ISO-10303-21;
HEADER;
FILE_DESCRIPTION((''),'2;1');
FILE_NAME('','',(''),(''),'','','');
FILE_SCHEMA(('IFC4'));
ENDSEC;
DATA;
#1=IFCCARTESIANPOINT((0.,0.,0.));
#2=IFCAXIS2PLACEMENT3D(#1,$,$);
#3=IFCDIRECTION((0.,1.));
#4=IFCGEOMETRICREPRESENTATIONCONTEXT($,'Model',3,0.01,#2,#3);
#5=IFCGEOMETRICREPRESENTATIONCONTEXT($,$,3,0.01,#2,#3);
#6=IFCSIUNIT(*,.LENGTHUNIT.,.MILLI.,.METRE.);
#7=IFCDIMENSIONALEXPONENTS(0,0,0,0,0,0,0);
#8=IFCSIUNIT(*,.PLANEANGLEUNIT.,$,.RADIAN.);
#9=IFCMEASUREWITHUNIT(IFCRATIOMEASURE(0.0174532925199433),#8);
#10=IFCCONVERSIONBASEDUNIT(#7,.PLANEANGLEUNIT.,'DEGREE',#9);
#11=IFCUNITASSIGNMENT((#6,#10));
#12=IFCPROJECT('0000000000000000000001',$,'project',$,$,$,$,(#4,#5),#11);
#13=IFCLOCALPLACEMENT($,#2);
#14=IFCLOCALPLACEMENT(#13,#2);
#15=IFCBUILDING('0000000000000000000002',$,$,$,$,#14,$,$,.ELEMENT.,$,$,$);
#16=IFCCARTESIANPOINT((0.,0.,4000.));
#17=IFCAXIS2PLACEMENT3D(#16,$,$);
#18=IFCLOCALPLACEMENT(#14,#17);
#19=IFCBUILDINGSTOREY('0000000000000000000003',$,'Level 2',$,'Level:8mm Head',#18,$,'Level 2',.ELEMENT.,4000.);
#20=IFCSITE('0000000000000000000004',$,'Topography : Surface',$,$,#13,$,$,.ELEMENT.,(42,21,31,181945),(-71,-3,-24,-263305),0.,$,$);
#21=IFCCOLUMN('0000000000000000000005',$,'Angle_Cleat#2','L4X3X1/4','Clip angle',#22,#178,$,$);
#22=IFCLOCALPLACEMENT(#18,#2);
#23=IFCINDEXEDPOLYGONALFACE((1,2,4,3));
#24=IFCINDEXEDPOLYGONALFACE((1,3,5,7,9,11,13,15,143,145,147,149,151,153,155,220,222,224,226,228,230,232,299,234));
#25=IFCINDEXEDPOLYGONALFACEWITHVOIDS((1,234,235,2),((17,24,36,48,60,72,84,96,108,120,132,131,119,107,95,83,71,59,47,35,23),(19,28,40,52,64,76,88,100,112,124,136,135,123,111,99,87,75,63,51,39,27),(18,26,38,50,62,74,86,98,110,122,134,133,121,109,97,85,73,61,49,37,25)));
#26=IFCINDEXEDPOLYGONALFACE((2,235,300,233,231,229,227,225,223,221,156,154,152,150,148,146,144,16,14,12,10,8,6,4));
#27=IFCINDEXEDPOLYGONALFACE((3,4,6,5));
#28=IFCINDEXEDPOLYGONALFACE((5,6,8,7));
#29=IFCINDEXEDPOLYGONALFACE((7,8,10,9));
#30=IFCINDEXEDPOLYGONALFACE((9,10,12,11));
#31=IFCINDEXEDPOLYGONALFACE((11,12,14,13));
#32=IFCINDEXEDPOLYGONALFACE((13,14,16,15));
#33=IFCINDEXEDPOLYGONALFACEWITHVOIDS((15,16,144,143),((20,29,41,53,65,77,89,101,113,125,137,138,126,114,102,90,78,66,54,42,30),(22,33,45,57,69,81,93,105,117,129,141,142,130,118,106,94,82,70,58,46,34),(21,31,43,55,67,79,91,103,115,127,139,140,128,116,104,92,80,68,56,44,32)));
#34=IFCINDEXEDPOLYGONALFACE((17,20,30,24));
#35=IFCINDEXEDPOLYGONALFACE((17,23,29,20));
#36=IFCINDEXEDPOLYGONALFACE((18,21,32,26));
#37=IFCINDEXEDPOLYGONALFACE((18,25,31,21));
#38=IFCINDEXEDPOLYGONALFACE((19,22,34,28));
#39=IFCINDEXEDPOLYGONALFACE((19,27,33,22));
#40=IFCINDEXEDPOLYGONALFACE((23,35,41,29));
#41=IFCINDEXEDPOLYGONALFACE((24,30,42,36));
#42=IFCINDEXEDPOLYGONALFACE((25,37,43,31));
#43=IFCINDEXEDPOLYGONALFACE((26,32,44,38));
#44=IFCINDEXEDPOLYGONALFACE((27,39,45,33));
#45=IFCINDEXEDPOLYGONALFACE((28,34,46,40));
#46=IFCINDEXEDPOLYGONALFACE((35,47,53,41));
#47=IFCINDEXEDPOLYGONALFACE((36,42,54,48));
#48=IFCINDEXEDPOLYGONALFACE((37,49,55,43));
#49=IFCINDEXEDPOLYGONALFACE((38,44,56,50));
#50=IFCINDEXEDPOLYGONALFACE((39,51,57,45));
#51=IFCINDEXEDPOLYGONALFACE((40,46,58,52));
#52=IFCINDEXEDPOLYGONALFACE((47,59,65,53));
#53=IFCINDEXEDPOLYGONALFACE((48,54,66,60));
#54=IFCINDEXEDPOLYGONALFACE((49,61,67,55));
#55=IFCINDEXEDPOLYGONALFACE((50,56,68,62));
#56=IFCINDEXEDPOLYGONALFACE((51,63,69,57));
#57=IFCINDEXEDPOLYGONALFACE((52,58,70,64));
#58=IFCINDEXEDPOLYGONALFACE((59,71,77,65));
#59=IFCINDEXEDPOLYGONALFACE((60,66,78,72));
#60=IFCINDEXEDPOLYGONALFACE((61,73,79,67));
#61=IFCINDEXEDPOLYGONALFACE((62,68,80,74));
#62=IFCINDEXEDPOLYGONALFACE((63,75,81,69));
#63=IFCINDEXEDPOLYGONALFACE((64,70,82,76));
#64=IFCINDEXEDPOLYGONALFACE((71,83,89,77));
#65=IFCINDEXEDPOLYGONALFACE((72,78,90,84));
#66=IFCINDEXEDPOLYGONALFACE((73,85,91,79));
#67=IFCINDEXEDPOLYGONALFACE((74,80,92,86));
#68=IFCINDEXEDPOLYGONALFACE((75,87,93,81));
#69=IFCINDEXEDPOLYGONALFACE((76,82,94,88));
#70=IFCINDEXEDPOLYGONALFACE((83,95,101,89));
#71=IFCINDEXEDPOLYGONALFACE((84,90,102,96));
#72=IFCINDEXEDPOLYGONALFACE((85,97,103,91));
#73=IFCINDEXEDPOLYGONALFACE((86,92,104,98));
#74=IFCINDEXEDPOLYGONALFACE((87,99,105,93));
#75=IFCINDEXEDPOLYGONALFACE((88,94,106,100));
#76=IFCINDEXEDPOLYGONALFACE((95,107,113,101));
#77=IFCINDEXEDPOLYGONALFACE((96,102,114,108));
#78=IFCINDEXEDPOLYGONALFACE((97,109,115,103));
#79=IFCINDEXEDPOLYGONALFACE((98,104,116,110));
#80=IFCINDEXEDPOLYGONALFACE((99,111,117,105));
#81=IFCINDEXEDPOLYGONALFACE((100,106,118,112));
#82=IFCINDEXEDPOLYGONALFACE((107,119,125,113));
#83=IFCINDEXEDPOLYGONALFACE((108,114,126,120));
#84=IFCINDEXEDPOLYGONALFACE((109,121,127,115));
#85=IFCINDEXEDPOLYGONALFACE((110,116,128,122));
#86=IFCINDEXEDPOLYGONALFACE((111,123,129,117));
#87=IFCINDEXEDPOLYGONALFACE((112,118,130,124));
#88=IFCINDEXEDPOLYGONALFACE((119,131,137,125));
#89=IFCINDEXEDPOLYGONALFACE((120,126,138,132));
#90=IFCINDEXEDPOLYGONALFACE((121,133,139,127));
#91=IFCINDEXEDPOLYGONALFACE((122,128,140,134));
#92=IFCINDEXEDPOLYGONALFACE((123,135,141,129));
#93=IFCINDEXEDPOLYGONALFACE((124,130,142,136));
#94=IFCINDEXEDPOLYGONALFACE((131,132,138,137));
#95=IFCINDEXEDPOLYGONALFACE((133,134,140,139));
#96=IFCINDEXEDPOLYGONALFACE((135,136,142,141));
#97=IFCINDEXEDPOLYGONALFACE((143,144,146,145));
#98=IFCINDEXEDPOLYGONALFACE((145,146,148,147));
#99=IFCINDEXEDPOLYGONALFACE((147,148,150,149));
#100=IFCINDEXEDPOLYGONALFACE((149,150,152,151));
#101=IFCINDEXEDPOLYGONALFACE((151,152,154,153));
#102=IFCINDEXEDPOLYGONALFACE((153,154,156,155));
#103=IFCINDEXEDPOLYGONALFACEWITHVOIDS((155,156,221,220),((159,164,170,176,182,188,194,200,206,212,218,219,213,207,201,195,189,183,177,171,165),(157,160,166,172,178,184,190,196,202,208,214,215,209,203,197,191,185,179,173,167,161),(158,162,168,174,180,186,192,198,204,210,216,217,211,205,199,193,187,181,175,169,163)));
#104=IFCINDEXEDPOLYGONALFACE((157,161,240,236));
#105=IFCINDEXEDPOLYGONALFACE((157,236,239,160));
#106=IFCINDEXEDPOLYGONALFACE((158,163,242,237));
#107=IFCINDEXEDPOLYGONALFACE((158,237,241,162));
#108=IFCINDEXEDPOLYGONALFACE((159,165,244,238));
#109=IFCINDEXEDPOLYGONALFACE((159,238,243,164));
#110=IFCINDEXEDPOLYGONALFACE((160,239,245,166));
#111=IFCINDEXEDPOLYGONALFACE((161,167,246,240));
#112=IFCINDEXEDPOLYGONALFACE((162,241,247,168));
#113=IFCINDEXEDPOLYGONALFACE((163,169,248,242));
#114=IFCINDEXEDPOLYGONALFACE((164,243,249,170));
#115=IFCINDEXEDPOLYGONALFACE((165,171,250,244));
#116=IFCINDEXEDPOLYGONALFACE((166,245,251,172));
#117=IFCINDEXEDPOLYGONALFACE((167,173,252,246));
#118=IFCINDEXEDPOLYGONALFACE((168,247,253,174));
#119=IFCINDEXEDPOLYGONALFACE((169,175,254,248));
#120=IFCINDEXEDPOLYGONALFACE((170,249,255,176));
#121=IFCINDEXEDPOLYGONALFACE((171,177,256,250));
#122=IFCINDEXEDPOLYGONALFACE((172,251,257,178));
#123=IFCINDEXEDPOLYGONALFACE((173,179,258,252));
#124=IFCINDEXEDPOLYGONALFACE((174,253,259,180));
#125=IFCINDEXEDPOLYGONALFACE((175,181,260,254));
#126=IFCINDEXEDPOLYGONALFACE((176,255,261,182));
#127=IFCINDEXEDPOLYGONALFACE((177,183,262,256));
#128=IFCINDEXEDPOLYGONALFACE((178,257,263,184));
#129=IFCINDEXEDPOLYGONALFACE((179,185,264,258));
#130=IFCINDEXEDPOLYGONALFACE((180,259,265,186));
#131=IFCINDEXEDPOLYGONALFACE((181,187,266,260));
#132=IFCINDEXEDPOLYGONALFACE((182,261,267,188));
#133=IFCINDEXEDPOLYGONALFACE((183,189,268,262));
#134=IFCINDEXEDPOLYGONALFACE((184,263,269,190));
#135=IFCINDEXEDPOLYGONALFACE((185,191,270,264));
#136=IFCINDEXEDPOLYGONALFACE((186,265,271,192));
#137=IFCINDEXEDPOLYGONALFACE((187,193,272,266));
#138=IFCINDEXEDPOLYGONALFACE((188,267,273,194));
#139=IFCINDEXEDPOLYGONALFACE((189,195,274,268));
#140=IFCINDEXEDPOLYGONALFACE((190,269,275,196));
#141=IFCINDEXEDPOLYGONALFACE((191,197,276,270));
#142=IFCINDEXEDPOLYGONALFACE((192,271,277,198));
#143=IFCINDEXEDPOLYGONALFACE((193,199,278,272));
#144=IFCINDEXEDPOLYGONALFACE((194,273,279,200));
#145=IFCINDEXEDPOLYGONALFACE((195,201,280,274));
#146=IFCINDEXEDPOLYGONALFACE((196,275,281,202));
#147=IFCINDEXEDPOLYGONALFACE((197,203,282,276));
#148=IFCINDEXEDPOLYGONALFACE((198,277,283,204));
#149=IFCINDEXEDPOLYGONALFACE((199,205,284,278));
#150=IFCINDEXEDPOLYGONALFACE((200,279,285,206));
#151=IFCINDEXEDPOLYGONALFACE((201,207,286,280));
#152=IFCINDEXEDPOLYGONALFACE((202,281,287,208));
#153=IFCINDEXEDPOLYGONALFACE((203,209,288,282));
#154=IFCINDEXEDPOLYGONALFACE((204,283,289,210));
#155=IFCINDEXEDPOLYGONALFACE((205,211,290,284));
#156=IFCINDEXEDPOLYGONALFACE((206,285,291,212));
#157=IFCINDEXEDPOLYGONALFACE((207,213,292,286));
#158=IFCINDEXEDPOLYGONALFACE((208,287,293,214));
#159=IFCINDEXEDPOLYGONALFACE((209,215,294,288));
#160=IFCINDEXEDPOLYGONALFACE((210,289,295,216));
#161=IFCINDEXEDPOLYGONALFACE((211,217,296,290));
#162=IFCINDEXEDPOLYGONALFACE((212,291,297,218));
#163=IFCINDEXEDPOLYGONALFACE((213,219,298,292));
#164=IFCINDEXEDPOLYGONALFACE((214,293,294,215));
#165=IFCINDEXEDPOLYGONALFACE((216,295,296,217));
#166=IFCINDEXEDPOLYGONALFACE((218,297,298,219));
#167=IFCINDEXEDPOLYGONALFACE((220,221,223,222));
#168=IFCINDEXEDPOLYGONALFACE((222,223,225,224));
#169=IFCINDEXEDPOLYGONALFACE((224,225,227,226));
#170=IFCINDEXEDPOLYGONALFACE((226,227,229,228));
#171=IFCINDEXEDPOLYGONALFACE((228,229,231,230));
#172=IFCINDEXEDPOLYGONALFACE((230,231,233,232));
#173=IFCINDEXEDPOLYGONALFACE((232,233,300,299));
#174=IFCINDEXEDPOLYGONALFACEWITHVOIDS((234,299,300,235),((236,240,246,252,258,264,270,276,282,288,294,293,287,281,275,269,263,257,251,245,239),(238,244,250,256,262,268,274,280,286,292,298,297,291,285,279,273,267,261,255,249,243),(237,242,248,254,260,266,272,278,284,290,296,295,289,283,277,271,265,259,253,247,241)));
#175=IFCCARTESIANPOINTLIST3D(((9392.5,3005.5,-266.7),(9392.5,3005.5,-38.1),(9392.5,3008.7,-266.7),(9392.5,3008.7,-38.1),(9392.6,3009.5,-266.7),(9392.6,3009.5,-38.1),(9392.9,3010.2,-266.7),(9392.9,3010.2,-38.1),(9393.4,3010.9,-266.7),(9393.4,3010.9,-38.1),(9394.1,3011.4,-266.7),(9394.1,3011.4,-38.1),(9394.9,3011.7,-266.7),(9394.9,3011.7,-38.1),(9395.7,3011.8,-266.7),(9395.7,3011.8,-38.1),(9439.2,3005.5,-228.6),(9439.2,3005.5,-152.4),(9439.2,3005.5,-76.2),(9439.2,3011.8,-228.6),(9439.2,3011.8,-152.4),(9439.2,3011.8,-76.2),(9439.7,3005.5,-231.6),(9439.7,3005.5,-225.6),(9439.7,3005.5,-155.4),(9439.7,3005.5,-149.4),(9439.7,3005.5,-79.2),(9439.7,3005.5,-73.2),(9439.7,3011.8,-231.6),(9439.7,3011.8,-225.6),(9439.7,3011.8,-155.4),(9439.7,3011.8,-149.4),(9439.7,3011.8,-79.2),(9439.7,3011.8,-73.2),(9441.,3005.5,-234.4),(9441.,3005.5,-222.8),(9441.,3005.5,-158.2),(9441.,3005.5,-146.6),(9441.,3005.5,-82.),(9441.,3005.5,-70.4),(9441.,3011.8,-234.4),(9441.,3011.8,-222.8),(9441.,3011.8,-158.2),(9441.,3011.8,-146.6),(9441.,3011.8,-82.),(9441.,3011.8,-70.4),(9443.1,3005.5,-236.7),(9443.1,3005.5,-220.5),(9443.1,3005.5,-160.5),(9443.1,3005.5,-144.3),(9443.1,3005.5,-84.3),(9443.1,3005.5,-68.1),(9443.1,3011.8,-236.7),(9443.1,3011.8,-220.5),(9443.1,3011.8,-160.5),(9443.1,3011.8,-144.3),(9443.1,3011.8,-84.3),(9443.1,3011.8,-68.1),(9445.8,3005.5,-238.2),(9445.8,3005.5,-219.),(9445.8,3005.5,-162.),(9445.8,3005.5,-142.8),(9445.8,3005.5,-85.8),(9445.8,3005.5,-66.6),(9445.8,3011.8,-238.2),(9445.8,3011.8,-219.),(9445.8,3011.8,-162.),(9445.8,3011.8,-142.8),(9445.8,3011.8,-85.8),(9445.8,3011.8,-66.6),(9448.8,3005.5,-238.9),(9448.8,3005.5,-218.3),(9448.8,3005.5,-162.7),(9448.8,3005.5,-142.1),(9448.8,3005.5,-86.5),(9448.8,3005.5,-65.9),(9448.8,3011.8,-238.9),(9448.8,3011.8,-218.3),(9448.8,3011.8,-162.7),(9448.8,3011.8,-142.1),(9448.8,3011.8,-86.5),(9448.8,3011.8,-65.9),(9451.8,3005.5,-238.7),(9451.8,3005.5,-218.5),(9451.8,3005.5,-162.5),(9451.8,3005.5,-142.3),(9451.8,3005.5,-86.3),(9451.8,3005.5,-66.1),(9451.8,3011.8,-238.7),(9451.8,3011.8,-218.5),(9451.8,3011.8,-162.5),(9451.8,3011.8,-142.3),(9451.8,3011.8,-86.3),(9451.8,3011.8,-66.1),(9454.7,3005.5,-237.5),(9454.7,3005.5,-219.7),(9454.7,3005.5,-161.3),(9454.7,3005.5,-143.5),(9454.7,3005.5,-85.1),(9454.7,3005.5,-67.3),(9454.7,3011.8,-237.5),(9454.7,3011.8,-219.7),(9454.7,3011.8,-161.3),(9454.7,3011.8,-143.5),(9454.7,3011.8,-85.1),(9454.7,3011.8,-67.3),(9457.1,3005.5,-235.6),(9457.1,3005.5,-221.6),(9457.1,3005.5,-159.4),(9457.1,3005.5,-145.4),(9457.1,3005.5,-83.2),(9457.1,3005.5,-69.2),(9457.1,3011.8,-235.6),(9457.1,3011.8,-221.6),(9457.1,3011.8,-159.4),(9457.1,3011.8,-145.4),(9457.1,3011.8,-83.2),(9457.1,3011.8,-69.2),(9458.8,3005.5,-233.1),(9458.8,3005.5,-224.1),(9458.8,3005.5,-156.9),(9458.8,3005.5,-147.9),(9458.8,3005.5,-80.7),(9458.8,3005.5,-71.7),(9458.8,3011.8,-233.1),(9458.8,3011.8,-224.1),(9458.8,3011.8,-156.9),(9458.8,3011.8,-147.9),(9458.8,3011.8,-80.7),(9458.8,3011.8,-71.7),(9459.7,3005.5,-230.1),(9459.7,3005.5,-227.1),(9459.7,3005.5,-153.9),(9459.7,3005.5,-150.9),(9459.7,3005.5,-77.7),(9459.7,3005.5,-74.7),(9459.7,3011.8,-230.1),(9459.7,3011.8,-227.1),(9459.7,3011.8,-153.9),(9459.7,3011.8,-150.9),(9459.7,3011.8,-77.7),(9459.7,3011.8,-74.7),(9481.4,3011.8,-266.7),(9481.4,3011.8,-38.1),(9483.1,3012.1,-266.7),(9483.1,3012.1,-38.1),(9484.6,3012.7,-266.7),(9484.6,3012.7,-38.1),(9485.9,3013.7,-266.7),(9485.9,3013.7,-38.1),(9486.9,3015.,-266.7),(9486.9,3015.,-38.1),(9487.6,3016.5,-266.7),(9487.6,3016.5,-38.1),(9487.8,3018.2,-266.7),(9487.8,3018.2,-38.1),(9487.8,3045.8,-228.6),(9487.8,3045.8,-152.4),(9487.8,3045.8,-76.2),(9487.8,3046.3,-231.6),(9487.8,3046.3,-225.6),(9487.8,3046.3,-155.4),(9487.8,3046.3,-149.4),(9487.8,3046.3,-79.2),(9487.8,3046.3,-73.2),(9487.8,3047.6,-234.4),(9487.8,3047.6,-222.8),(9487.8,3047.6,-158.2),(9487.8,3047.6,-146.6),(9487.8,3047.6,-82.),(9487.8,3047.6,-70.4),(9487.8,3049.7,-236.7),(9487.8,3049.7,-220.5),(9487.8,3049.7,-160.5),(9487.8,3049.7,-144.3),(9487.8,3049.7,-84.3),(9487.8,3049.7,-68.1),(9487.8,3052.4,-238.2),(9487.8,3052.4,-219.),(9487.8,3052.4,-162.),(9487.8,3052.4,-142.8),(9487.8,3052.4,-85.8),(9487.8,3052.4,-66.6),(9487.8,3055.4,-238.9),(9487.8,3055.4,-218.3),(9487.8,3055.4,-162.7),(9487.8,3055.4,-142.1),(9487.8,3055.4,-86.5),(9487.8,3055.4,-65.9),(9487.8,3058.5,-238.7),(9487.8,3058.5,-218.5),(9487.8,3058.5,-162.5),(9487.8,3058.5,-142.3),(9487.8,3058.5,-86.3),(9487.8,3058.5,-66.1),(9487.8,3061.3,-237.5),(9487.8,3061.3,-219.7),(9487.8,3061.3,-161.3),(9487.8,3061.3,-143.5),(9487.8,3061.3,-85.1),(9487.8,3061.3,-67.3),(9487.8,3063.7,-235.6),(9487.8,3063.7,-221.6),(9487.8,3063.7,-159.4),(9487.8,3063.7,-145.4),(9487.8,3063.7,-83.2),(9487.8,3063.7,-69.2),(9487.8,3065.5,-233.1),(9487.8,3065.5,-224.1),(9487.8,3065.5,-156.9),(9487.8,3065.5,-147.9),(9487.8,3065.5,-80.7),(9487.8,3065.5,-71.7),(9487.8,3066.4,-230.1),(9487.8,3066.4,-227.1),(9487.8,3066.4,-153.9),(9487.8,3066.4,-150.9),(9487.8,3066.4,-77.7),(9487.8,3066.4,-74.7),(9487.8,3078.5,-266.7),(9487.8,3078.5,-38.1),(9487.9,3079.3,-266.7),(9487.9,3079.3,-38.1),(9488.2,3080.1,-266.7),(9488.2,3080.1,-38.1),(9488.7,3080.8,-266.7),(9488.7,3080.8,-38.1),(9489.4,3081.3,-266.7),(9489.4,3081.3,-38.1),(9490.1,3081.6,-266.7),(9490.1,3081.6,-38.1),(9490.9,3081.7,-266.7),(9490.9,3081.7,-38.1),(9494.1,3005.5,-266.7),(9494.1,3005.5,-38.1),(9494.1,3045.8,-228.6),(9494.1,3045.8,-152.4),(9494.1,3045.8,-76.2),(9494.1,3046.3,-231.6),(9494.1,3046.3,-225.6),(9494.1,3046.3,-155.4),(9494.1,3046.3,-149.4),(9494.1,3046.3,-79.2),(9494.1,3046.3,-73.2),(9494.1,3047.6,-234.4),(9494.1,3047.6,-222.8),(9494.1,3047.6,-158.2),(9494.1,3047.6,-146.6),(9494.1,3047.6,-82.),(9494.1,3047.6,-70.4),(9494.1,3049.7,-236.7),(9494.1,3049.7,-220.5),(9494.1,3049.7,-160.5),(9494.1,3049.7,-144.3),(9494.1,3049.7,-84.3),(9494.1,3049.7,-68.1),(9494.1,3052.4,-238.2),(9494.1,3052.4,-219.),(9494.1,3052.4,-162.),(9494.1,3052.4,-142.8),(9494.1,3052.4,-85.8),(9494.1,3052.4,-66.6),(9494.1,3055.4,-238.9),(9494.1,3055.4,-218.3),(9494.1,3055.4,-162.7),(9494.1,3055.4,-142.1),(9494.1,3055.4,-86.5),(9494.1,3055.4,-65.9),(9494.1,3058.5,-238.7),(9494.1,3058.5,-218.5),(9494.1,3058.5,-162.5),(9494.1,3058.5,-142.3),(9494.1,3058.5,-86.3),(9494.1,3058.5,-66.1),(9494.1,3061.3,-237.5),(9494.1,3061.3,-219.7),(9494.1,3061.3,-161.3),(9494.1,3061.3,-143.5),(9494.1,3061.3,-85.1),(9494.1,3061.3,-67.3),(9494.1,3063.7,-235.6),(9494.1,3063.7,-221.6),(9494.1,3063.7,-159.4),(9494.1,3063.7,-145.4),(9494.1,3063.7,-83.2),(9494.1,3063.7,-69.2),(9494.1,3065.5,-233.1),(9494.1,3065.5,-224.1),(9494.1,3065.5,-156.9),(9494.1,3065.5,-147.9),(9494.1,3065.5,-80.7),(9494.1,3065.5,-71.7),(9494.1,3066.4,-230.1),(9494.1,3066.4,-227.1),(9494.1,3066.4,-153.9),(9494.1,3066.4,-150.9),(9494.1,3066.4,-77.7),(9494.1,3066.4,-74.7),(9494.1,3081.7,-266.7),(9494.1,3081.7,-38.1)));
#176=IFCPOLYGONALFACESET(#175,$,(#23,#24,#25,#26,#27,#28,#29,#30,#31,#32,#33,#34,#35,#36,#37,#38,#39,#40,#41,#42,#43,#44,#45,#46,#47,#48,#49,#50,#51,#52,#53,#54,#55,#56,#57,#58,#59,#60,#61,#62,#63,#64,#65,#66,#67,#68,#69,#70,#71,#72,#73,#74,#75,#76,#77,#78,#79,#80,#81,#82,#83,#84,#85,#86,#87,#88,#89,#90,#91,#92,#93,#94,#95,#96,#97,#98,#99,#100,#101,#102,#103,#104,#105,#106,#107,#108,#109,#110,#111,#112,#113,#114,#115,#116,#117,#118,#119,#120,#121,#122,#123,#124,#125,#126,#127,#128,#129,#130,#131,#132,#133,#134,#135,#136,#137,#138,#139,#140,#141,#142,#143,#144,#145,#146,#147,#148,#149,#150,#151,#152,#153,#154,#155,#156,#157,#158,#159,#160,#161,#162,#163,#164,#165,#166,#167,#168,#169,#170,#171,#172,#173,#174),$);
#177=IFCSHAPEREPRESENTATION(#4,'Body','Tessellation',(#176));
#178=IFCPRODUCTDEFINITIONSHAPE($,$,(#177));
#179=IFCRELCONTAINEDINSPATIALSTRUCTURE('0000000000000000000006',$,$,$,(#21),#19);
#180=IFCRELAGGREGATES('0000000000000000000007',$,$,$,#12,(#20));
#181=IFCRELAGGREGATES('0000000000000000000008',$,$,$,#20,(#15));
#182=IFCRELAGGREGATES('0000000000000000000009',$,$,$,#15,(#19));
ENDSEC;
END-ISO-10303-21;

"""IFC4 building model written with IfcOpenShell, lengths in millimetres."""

from ifc_helpers import new_model, entity, si_unit, converted_unit, direction, frame, frame_2d, origin, origin_2d_with_axis, place, context, project, spatial, circle, l_section, extrude, element, save


model = new_model("IFC4")

# Units and contexts
model_context = context("Model", 3, precision=0.01, world=origin(), true_north=direction((0.0, 1.0)))
context_of_model = context(None, 3, precision=0.01, world=origin(), true_north=direction((0.0, 1.0)))
ifc_project = project(units=[si_unit("LENGTHUNIT", "METRE", prefix="MILLI"), converted_unit("PLANEANGLEUNIT", "DEGREE", entity("IfcRatioMeasure", 0.0174532925199433), si_unit("PLANEANGLEUNIT", "RADIAN"), dimensions=[0, 0, 0, 0, 0, 0, 0])], contexts=[model_context, context_of_model])

# Site, building, storey
site_placement = place(None, origin())
site = spatial("IfcSite", under=ifc_project, at=site_placement, Name="Topography : Surface", CompositionType="ELEMENT", RefLatitude=(42, 21, 31, 181945), RefLongitude=(-71, -3, -24, -263305), RefElevation=0.0)
building_placement = place(site_placement, origin())
building = spatial("IfcBuilding", under=site, at=building_placement, CompositionType="ELEMENT")
storey_placement = place(building_placement, frame((0.0, 0.0, 4000.0)))
storey = spatial("IfcBuildingStorey", under=building, at=storey_placement, Name="Level 2", ObjectType="Level:8mm Head", LongName="Level 2", CompositionType="ELEMENT", Elevation=4000.0)

# Column, openings
column_1_placement = place(storey_placement, frame((9463.0, 3023.8, -38.1), z_axis=(0.0, 0.0, 1.0), x_axis=(0.0, 1.0, 0.0)))
column_1 = element("IfcColumn", 1, at=column_1_placement, inside=storey, Name="Angle_Cleat#2", Description="L4X3X1/4", ObjectType="Clip angle", context=model_context, shape_type="SweptSolid", body=[
    extrude(l_section(Depth=101.6, Width=76.2, Thickness=6.3, FilletRadius=6.3, EdgeRadius=3.2, at=frame_2d((19.8, 19.7))), origin(), (0.0, 0.0, -1.0), 228.6),
])
opening_1_placement = place(column_1_placement, frame((32.4, -31.5, -114.3), z_axis=(0.0, 1.0, 0.0), x_axis=(-1.0, 0.0, 0.0)))
element("IfcOpeningElement", 2, at=opening_1_placement, cuts=column_1, ObjectType="Opening", context=model_context, shape_type="SweptSolid", body=[
    extrude(circle(Radius=10.3, at=origin_2d_with_axis()), origin(), (0.0, 0.0, 1.0), 7.3),
])
opening_2_placement = place(column_1_placement, frame((32.4, -31.5, -114.3), z_axis=(0.0, 1.0, 0.0), x_axis=(-1.0, 0.0, 0.0)))
element("IfcOpeningElement", 3, at=opening_2_placement, cuts=column_1, ObjectType="Opening", context=model_context, shape_type="SweptSolid", body=[
    extrude(circle(Radius=10.3, at=frame_2d((0.0, 76.2), x_axis=(1.0, 0.0))), origin(), (0.0, 0.0, 1.0), 7.3),
])
opening_3_placement = place(column_1_placement, frame((32.4, -31.5, -114.3), z_axis=(0.0, 1.0, 0.0), x_axis=(-1.0, 0.0, 0.0)))
element("IfcOpeningElement", 4, at=opening_3_placement, cuts=column_1, ObjectType="Opening", context=model_context, shape_type="SweptSolid", body=[
    extrude(circle(Radius=10.3, at=frame_2d((0.0, -76.2), x_axis=(1.0, 0.0))), origin(), (0.0, 0.0, 1.0), 7.3),
])
opening_4_placement = place(column_1_placement, frame((-11.6, 13.5, -114.3), z_axis=(-1.0, 0.0, 0.0), x_axis=(0.0, 1.0, 0.0)))
element("IfcOpeningElement", 5, at=opening_4_placement, cuts=column_1, ObjectType="Opening", context=model_context, shape_type="SweptSolid", body=[
    extrude(circle(Radius=10.3, at=origin_2d_with_axis()), origin(), (0.0, 0.0, 1.0), 7.3),
])
opening_5_placement = place(column_1_placement, frame((-11.6, 13.5, -114.3), z_axis=(-1.0, 0.0, 0.0), x_axis=(0.0, 1.0, 0.0)))
element("IfcOpeningElement", 6, at=opening_5_placement, cuts=column_1, ObjectType="Opening", context=model_context, shape_type="SweptSolid", body=[
    extrude(circle(Radius=10.3, at=frame_2d((0.0, 76.2), x_axis=(1.0, 0.0))), origin(), (0.0, 0.0, 1.0), 7.3),
])
opening_6_placement = place(column_1_placement, frame((-11.6, 13.5, -114.3), z_axis=(-1.0, 0.0, 0.0), x_axis=(0.0, 1.0, 0.0)))
element("IfcOpeningElement", 7, at=opening_6_placement, cuts=column_1, ObjectType="Opening", context=model_context, shape_type="SweptSolid", body=[
    extrude(circle(Radius=10.3, at=frame_2d((0.0, -76.2), x_axis=(1.0, 0.0))), origin(), (0.0, 0.0, 1.0), 7.3),
])

save(model, "model.ifc")
